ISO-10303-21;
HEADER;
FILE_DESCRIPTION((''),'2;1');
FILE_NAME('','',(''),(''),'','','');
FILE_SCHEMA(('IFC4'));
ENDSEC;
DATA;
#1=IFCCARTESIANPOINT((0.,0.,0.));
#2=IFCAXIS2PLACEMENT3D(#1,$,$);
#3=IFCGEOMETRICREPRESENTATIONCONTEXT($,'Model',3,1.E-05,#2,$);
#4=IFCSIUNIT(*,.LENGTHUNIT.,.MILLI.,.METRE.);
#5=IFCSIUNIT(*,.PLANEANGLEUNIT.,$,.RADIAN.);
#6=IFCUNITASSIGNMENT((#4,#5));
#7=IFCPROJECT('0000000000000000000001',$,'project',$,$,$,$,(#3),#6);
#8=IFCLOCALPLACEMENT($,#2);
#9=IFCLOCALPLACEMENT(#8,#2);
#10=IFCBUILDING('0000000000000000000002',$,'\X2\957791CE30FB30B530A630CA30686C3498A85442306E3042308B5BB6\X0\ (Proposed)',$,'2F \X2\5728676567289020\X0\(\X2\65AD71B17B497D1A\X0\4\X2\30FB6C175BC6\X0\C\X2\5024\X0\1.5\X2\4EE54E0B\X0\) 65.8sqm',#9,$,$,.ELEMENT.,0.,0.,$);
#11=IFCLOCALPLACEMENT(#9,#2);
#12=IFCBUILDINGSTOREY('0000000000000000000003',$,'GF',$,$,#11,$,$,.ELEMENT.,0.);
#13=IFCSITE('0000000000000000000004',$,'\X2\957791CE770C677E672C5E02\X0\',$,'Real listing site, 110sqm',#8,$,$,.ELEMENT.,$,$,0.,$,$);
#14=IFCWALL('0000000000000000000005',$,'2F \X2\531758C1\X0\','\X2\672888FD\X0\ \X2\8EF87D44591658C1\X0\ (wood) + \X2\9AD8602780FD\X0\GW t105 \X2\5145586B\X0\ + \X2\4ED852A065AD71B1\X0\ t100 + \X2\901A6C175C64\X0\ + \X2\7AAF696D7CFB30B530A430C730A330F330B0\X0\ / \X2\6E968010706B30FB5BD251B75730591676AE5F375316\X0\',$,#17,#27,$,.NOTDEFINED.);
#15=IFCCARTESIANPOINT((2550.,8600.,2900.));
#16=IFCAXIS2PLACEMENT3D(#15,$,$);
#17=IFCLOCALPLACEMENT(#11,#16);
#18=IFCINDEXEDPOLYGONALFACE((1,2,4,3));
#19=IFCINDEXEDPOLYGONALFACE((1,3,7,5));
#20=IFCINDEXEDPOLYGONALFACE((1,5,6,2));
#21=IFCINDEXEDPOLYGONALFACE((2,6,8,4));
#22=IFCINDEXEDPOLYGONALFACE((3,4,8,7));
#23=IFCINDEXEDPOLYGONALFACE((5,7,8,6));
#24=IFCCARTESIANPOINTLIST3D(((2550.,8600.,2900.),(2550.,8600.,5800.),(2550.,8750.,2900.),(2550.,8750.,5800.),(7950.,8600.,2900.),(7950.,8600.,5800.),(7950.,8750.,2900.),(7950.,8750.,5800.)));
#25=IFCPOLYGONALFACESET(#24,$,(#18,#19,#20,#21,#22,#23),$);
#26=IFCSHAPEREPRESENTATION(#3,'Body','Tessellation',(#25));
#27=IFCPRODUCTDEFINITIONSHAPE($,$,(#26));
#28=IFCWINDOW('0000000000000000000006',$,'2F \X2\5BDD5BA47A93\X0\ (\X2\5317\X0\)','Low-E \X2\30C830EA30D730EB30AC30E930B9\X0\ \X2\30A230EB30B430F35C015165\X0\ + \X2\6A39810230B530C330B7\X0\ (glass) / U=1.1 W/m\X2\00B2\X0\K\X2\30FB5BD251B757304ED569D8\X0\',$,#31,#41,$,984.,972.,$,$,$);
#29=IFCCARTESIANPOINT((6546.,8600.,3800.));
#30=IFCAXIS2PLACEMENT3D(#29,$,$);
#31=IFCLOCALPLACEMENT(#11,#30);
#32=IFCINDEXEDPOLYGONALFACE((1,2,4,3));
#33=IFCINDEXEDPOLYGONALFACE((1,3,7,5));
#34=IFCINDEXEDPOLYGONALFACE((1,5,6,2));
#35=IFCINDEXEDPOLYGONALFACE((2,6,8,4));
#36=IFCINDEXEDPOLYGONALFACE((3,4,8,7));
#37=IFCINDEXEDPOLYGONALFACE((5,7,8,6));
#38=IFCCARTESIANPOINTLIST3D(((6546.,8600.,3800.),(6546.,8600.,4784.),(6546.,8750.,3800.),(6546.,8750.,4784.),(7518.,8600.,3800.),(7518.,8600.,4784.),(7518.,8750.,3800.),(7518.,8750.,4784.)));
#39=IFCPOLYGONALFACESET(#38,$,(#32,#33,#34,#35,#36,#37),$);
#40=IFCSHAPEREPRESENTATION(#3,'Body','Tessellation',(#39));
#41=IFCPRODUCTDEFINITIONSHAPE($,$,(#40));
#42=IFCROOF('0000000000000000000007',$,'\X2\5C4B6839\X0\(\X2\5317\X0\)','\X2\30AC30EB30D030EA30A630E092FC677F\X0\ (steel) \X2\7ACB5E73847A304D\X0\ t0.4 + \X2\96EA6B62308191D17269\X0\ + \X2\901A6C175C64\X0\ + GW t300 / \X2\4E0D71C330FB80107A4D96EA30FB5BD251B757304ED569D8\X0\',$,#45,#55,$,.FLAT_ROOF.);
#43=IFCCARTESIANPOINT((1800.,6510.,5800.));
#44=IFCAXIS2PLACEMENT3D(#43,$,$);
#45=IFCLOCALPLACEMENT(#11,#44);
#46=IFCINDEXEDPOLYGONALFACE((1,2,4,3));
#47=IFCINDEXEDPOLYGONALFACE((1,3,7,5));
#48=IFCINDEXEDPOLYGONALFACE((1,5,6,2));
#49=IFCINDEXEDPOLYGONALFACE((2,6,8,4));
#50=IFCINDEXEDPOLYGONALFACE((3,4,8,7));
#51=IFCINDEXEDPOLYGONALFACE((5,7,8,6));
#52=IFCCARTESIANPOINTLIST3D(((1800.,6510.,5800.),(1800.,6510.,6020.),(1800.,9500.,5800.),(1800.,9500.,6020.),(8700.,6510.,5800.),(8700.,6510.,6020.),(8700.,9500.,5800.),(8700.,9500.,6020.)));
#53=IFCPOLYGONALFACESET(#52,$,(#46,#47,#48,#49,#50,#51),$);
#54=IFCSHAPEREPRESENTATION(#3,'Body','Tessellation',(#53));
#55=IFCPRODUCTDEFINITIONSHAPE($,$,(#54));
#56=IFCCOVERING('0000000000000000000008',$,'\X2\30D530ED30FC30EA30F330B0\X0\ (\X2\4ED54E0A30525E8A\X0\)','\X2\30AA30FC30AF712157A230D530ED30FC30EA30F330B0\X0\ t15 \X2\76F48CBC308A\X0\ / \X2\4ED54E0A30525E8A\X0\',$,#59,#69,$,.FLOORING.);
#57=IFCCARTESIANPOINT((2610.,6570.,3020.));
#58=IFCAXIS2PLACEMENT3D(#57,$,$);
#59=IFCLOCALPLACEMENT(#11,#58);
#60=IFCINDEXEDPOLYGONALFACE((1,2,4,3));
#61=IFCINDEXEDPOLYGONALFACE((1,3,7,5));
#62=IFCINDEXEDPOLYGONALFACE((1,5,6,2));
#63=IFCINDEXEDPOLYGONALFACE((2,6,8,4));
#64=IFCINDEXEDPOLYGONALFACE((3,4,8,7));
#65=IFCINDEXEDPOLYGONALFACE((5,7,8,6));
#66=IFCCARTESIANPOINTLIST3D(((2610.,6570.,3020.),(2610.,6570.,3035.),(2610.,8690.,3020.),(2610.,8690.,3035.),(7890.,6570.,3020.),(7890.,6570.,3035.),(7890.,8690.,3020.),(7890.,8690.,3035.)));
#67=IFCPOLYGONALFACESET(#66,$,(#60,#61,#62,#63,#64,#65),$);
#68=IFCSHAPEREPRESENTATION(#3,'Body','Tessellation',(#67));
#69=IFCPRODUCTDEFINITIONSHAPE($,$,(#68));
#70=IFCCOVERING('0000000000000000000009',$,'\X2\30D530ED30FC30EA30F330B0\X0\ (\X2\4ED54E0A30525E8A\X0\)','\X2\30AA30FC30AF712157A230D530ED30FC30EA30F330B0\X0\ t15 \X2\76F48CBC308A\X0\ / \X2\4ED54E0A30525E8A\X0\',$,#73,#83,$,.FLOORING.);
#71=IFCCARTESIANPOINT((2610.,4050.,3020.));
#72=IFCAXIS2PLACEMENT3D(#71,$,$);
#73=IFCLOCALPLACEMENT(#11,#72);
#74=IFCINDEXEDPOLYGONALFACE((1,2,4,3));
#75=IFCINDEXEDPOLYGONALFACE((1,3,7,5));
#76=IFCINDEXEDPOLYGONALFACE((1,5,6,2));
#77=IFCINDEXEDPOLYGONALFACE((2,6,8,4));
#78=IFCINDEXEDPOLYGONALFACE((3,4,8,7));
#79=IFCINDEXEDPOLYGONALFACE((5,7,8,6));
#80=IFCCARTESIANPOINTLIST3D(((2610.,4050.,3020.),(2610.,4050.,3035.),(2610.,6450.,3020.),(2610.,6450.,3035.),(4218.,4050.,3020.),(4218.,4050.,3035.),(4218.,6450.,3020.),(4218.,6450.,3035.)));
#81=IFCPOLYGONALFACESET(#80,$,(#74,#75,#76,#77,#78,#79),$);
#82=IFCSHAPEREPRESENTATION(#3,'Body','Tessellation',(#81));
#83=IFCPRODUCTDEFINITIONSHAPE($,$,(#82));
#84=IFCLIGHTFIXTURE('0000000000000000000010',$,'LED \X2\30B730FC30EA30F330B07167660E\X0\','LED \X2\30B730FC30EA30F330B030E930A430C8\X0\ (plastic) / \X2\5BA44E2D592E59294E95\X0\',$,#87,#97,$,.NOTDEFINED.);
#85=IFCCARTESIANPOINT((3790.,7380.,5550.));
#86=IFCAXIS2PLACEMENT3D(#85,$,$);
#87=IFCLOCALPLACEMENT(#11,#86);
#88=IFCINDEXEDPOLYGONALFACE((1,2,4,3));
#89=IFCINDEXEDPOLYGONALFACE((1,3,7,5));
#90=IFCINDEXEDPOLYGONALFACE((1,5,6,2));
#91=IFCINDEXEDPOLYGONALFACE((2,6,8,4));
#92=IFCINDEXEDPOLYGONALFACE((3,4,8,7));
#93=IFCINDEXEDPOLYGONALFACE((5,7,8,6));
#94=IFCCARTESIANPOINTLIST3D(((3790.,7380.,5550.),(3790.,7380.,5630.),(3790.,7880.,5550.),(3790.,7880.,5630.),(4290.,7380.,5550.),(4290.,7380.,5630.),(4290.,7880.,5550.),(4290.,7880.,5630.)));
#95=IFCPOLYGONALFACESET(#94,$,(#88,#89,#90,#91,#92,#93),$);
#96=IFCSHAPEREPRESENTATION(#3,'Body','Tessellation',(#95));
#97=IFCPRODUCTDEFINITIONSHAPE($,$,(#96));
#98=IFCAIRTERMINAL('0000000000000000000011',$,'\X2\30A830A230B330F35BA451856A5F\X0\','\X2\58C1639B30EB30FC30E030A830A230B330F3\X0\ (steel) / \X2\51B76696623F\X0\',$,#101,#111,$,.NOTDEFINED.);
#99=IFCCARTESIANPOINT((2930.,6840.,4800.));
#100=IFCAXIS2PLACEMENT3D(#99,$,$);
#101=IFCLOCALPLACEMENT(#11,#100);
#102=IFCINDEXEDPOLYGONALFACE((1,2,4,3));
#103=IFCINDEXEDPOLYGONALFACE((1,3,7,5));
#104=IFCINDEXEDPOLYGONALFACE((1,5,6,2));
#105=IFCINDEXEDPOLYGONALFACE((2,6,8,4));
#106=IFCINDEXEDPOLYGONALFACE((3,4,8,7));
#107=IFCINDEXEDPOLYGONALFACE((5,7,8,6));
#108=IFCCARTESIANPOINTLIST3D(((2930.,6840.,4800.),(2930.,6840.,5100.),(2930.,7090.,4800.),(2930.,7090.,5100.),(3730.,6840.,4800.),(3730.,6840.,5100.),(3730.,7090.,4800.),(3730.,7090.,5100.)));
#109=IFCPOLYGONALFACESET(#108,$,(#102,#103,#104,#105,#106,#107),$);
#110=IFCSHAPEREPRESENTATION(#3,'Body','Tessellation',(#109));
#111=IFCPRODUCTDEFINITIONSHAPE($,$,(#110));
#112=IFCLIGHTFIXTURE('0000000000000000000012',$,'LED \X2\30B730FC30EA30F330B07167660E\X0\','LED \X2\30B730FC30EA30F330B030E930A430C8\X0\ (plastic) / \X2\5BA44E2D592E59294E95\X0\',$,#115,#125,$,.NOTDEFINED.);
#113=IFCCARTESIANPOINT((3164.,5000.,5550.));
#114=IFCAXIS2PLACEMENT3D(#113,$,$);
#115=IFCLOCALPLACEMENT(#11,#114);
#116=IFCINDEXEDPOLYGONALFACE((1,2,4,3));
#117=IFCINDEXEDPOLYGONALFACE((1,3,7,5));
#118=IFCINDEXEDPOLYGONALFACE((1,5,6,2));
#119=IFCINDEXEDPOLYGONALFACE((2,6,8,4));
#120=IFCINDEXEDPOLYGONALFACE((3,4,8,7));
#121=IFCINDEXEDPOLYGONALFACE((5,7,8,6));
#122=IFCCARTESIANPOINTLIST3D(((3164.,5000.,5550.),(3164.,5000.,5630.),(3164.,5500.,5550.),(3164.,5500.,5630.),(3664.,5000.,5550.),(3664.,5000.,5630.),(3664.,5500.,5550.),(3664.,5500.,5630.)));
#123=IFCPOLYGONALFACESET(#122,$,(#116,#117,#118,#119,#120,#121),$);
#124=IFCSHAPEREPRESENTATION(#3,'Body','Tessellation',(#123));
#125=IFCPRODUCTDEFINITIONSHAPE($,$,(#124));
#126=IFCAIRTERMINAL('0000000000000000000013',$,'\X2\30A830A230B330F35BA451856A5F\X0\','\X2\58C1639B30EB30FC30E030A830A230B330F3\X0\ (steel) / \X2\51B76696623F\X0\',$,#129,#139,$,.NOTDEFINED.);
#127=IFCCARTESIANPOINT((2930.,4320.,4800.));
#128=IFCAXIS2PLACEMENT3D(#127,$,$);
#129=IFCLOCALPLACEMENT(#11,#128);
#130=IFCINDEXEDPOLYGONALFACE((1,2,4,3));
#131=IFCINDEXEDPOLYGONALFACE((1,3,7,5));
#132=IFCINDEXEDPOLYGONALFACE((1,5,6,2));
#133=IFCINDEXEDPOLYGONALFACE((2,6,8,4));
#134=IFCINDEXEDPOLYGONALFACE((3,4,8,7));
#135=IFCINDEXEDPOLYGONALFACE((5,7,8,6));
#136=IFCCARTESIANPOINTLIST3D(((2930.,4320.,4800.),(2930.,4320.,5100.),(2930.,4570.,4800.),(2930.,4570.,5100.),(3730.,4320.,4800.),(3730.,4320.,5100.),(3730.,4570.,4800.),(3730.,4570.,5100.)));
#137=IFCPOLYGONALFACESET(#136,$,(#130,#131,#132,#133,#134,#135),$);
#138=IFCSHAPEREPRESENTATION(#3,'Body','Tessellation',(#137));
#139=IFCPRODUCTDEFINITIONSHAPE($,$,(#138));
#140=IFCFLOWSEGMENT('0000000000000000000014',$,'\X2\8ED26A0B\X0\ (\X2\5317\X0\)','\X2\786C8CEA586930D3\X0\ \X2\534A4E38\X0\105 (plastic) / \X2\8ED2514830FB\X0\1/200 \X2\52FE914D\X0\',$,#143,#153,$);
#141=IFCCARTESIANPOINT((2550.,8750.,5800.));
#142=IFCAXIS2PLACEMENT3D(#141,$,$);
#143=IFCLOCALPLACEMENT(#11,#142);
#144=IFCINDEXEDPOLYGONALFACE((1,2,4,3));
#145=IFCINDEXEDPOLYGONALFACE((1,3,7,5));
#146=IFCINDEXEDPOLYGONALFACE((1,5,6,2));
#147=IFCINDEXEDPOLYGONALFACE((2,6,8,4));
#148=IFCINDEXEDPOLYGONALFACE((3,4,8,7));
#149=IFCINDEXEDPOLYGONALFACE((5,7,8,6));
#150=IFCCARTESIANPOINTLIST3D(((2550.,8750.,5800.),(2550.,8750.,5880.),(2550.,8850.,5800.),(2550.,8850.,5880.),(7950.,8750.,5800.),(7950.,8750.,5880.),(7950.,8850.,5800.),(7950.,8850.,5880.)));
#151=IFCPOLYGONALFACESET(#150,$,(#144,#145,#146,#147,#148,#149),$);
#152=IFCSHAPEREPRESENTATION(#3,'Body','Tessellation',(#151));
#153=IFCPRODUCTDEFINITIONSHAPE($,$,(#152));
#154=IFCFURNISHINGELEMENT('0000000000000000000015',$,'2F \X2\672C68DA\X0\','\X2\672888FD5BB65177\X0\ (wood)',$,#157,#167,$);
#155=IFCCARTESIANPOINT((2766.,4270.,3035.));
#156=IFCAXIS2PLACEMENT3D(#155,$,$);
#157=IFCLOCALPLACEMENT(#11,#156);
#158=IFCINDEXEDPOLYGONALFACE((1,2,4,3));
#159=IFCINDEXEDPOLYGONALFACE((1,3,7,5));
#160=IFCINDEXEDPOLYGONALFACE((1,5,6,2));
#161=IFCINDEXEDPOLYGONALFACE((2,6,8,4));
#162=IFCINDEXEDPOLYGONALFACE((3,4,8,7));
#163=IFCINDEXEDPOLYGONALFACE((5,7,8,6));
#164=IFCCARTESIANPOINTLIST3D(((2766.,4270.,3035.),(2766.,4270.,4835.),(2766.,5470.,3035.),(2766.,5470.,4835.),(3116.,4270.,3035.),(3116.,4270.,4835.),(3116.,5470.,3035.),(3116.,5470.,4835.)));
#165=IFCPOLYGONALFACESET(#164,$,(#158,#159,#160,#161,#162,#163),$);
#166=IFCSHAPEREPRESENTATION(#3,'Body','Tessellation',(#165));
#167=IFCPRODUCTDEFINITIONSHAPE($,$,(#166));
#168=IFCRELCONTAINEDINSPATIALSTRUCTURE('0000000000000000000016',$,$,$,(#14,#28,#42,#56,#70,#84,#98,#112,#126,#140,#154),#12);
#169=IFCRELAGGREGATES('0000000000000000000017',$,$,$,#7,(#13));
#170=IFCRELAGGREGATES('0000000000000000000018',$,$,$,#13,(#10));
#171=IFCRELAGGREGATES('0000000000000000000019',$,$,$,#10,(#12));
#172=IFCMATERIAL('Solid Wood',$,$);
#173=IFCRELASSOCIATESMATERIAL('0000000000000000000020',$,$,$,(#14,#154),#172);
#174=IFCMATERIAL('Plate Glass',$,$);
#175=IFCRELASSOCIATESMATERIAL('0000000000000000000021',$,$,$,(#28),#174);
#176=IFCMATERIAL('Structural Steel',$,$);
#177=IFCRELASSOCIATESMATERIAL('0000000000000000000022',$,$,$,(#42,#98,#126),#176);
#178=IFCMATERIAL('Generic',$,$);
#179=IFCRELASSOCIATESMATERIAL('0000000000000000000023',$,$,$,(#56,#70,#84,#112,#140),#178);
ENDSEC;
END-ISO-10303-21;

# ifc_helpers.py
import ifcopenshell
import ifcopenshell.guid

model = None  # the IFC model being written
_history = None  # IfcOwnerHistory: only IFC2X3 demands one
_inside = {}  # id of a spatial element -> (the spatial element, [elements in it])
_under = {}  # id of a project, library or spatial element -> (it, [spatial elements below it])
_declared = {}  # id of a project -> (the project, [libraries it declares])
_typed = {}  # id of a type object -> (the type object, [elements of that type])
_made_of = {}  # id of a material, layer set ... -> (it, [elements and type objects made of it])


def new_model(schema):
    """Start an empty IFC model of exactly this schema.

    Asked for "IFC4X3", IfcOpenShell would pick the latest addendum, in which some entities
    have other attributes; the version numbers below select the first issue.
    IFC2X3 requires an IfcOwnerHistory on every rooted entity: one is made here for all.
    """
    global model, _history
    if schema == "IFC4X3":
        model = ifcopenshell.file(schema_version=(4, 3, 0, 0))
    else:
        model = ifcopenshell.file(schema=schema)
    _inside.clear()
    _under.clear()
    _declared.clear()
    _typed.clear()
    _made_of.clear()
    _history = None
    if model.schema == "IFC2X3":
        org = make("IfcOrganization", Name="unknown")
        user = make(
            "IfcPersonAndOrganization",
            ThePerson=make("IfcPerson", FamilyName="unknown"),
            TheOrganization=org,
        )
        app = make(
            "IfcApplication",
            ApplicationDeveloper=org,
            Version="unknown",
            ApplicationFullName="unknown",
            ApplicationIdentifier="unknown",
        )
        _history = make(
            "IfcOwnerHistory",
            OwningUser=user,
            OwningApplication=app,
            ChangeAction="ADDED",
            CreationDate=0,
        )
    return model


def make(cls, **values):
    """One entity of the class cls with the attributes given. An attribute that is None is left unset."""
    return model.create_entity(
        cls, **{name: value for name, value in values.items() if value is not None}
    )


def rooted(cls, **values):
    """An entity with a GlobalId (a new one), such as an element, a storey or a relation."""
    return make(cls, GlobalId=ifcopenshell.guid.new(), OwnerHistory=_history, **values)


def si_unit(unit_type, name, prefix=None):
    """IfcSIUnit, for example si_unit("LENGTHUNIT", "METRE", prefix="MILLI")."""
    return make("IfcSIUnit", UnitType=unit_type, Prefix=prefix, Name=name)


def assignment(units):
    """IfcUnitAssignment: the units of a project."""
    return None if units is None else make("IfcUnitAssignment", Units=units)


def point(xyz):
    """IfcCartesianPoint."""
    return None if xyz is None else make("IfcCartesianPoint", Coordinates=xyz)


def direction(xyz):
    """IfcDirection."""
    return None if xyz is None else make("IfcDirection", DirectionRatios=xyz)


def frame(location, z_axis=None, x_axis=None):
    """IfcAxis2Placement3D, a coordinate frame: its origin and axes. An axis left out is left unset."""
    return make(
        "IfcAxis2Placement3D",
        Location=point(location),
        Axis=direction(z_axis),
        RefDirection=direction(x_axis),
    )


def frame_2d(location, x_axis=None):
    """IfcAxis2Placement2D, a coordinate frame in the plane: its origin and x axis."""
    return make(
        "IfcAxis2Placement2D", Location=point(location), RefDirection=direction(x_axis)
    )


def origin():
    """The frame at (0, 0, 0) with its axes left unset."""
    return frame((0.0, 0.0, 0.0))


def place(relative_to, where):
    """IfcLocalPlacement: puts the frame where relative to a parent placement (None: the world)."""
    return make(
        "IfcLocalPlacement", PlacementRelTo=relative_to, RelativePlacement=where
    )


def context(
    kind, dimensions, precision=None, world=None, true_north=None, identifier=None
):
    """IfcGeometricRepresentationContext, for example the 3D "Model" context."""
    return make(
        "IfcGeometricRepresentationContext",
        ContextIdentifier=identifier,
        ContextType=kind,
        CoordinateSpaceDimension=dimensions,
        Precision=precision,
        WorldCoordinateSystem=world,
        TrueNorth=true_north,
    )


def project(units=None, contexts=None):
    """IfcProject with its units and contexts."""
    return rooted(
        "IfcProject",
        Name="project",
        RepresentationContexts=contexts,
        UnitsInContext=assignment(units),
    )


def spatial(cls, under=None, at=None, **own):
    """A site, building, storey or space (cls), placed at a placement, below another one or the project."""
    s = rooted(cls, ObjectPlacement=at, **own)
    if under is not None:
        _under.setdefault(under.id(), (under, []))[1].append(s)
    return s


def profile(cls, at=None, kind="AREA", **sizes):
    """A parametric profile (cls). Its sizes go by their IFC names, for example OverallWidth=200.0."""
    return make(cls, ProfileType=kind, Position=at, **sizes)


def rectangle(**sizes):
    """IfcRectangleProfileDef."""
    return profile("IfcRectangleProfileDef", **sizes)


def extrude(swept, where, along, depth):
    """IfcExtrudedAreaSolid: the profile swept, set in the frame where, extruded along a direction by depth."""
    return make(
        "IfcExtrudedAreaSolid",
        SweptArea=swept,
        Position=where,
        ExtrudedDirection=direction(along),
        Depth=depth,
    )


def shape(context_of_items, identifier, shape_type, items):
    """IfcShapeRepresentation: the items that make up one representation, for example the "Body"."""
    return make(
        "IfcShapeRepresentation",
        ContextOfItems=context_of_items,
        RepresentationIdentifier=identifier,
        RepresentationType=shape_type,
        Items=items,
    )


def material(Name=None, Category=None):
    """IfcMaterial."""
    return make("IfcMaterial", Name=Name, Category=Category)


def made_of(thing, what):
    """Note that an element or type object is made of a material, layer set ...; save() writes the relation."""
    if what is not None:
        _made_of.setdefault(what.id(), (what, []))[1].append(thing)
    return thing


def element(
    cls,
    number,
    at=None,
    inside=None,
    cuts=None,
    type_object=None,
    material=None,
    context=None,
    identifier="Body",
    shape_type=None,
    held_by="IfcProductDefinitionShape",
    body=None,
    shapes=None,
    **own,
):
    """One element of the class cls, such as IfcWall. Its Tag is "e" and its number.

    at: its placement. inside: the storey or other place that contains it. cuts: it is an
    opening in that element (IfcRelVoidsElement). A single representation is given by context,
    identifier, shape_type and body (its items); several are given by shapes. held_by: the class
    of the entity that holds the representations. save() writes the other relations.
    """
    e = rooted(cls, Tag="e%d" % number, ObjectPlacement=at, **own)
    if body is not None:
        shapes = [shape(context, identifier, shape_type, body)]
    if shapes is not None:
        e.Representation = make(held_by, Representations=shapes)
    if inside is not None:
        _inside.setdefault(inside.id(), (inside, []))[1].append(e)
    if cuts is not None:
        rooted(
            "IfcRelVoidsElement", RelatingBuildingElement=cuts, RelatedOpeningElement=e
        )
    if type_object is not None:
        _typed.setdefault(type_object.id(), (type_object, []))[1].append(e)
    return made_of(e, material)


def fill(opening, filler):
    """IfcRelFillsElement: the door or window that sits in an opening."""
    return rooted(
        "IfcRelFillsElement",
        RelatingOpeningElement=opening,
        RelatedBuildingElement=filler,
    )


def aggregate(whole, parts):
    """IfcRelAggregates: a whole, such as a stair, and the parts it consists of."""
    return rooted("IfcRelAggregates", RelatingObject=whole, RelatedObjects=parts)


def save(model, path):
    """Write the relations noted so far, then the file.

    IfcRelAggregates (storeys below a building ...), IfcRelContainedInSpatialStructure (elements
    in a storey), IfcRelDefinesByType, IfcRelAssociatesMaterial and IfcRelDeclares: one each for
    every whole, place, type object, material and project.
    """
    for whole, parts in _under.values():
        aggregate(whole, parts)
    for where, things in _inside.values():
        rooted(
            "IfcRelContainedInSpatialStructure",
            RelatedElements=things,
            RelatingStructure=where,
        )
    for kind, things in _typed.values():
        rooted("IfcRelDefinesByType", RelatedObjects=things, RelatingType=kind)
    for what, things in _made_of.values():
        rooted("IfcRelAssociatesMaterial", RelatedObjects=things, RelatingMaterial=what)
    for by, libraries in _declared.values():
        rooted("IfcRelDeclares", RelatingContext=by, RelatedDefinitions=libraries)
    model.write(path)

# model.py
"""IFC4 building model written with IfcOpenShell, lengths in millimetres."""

from ifc_helpers import new_model, si_unit, frame, frame_2d, origin, place, context, project, spatial, rectangle, extrude, material, element, fill, save


model = new_model("IFC4")

# Units and contexts
model_context = context("Model", 3, precision=1e-05, world=origin())
ifc_project = project(units=[si_unit("LENGTHUNIT", "METRE", prefix="MILLI"), si_unit("PLANEANGLEUNIT", "RADIAN")], contexts=[model_context])

# Site, building, storey
site_placement = place(None, origin())
site = spatial("IfcSite", under=ifc_project, at=site_placement, Name="長野県松本市", ObjectType="Real listing site, 110sqm", CompositionType="ELEMENT", RefElevation=0.0)
building_placement = place(site_placement, origin())
building = spatial("IfcBuilding", under=site, at=building_placement, Name="長野・サウナと水風呂のある家 (Proposed)", ObjectType="2F 在来木造(断熱等級4・気密C値1.5以下) 65.8sqm", CompositionType="ELEMENT", ElevationOfRefHeight=0.0, ElevationOfTerrain=0.0)
storey_placement = place(building_placement, origin())
storey = spatial("IfcBuildingStorey", under=building, at=storey_placement, Name="GF", CompositionType="ELEMENT", Elevation=0.0)

# Shared definitions
ifc_material_1 = material(Name="Solid Wood")

# Wall, opening, window
wall_placement = place(storey_placement, frame((2550.0, 8600.0, 2900.0)))
wall = element("IfcWall", 1, at=wall_placement, inside=storey, material=ifc_material_1, Name="2F 北壁", Description="木製 軸組外壁 (wood) + 高性能GW t105 充填 + 付加断熱 t100 + 通気層 + 窯業系サイディング / 準耐火・寒冷地外皮強化", PredefinedType="NOTDEFINED", context=model_context, shape_type="SweptSolid", body=[
    extrude(rectangle(XDim=5400.0, YDim=150.0, at=frame_2d((2700.0, 75.0))), frame((2550.0, 8600.0, 2900.0)), (0.0, 0.0, 1.0), 2900.0),
])
opening_placement = place(storey_placement, frame((6546.0, 8600.0, 3800.0)))
opening = element("IfcOpeningElement", 2, at=opening_placement, cuts=wall, PredefinedType="NOTDEFINED", context=model_context, shape_type="SweptSolid", body=[
    extrude(rectangle(XDim=972.0, YDim=150.0, at=frame_2d((486.0, 75.0))), frame((6546.0, 8600.0, 3800.0)), (0.0, 0.0, 1.0), 984.0),
])
ifc_material_2 = material(Name="Plate Glass")
window_placement = place(storey_placement, frame((6546.0, 8600.0, 3800.0)))
window = element("IfcWindow", 3, at=window_placement, inside=storey, material=ifc_material_2, Name="2F 寝室窓 (北)", Description="Low-E トリプルガラス アルゴン封入 + 樹脂サッシ (glass) / U=1.1 W/m²K・寒冷地仕様", OverallHeight=984.0, OverallWidth=972.0, context=model_context, shape_type="SweptSolid", body=[
    extrude(rectangle(XDim=972.0, YDim=150.0, at=frame_2d((486.0, 75.0))), frame((6546.0, 8600.0, 3800.0)), (0.0, 0.0, 1.0), 984.0),
])
fill(opening, window)

# Roof
ifc_material_3 = material(Name="Structural Steel")
for number, where, name in (
    (4, (1800.0, 6510.0, 5800.0), "屋根(北)"),
):
    element("IfcRoof", number, at=place(storey_placement, frame(where)), inside=storey, material=ifc_material_3, Name=name, Description="ガルバリウム鋼板 (steel) 立平葺き t0.4 + 雪止め金物 + 通気層 + GW t300 / 不燃・耐積雪・寒冷地仕様", PredefinedType="FLAT_ROOF", context=model_context, shape_type="SweptSolid", body=[
        extrude(rectangle(XDim=6900.0, YDim=2990.0, at=frame_2d((3450.0, 1495.0))), frame((1800.0, 6510.0, 5800.0)), (0.0, 0.0, 1.0), 220.0),
    ])

# Coverings
ifc_material_4 = material(Name="Generic")
covering_1_placement = place(storey_placement, frame((2610.0, 6570.0, 3020.0)))
element("IfcCovering", 5, at=covering_1_placement, inside=storey, material=ifc_material_4, Name="フローリング (仕上げ床)", Description="オーク無垢フローリング t15 直貼り / 仕上げ床", PredefinedType="FLOORING", context=model_context, shape_type="SweptSolid", body=[
    extrude(rectangle(XDim=5280.0, YDim=2120.0, at=frame_2d((2640.0, 1060.0))), frame((2610.0, 6570.0, 3020.0)), (0.0, 0.0, 1.0), 15.0),
])
covering_2_placement = place(storey_placement, frame((2610.0, 4050.0, 3020.0)))
element("IfcCovering", 6, at=covering_2_placement, inside=storey, material=ifc_material_4, Name="フローリング (仕上げ床)", Description="オーク無垢フローリング t15 直貼り / 仕上げ床", PredefinedType="FLOORING", context=model_context, shape_type="SweptSolid", body=[
    extrude(rectangle(XDim=1608.0, YDim=2400.0, at=frame_2d((804.0, 1200.0))), frame((2610.0, 4050.0, 3020.0)), (0.0, 0.0, 1.0), 15.0),
])

# Light fixture
light_fixture_1_placement = place(storey_placement, frame((3790.0, 7380.0, 5550.0)))
element("IfcLightFixture", 7, at=light_fixture_1_placement, inside=storey, material=ifc_material_4, Name="LED シーリング照明", Description="LED シーリングライト (plastic) / 室中央天井", PredefinedType="NOTDEFINED", context=model_context, shape_type="SweptSolid", body=[
    extrude(rectangle(XDim=500.0, YDim=500.0, at=frame_2d((250.0, 250.0))), frame((3790.0, 7380.0, 5550.0)), (0.0, 0.0, 1.0), 80.0),
])

# Air terminal
air_terminal_1_placement = place(storey_placement, frame((2930.0, 6840.0, 4800.0)))
element("IfcAirTerminal", 8, at=air_terminal_1_placement, inside=storey, material=ifc_material_3, Name="エアコン室内機", Description="壁掛ルームエアコン (steel) / 冷暖房", PredefinedType="NOTDEFINED", context=model_context, shape_type="SweptSolid", body=[
    extrude(rectangle(XDim=800.0, YDim=250.0, at=frame_2d((400.0, 125.0))), frame((2930.0, 6840.0, 4800.0)), (0.0, 0.0, 1.0), 300.0),
])

# Light fixture
light_fixture_2_placement = place(storey_placement, frame((3164.0, 5000.0, 5550.0)))
element("IfcLightFixture", 9, at=light_fixture_2_placement, inside=storey, material=ifc_material_4, Name="LED シーリング照明", Description="LED シーリングライト (plastic) / 室中央天井", PredefinedType="NOTDEFINED", context=model_context, shape_type="SweptSolid", body=[
    extrude(rectangle(XDim=500.0, YDim=500.0, at=frame_2d((250.0, 250.0))), frame((3164.0, 5000.0, 5550.0)), (0.0, 0.0, 1.0), 80.0),
])

# Air terminal
air_terminal_2_placement = place(storey_placement, frame((2930.0, 4320.0, 4800.0)))
element("IfcAirTerminal", 10, at=air_terminal_2_placement, inside=storey, material=ifc_material_3, Name="エアコン室内機", Description="壁掛ルームエアコン (steel) / 冷暖房", PredefinedType="NOTDEFINED", context=model_context, shape_type="SweptSolid", body=[
    extrude(rectangle(XDim=800.0, YDim=250.0, at=frame_2d((400.0, 125.0))), frame((2930.0, 4320.0, 4800.0)), (0.0, 0.0, 1.0), 300.0),
])

# Flow segment
flow_segment_placement = place(storey_placement, frame((2550.0, 8750.0, 5800.0)))
element("IfcFlowSegment", 11, at=flow_segment_placement, inside=storey, material=ifc_material_4, Name="軒樋 (北)", Description="硬質塩ビ 半丸105 (plastic) / 軒先・1/200 勾配", context=model_context, shape_type="SweptSolid", body=[
    extrude(rectangle(XDim=5400.0, YDim=100.0, at=frame_2d((2700.0, 50.0))), frame((2550.0, 8750.0, 5800.0)), (0.0, 0.0, 1.0), 80.0),
])

# Furnishing element
furnishing_placement = place(storey_placement, frame((2766.0, 4270.0, 3035.0)))
element("IfcFurnishingElement", 12, at=furnishing_placement, inside=storey, material=ifc_material_1, Name="2F 本棚", Description="木製家具 (wood)", context=model_context, shape_type="SweptSolid", body=[
    extrude(rectangle(XDim=350.0, YDim=1200.0, at=frame_2d((175.0, 600.0))), frame((2766.0, 4270.0, 3035.0)), (0.0, 0.0, 1.0), 1800.0),
])

save(model, "model.ifc")
